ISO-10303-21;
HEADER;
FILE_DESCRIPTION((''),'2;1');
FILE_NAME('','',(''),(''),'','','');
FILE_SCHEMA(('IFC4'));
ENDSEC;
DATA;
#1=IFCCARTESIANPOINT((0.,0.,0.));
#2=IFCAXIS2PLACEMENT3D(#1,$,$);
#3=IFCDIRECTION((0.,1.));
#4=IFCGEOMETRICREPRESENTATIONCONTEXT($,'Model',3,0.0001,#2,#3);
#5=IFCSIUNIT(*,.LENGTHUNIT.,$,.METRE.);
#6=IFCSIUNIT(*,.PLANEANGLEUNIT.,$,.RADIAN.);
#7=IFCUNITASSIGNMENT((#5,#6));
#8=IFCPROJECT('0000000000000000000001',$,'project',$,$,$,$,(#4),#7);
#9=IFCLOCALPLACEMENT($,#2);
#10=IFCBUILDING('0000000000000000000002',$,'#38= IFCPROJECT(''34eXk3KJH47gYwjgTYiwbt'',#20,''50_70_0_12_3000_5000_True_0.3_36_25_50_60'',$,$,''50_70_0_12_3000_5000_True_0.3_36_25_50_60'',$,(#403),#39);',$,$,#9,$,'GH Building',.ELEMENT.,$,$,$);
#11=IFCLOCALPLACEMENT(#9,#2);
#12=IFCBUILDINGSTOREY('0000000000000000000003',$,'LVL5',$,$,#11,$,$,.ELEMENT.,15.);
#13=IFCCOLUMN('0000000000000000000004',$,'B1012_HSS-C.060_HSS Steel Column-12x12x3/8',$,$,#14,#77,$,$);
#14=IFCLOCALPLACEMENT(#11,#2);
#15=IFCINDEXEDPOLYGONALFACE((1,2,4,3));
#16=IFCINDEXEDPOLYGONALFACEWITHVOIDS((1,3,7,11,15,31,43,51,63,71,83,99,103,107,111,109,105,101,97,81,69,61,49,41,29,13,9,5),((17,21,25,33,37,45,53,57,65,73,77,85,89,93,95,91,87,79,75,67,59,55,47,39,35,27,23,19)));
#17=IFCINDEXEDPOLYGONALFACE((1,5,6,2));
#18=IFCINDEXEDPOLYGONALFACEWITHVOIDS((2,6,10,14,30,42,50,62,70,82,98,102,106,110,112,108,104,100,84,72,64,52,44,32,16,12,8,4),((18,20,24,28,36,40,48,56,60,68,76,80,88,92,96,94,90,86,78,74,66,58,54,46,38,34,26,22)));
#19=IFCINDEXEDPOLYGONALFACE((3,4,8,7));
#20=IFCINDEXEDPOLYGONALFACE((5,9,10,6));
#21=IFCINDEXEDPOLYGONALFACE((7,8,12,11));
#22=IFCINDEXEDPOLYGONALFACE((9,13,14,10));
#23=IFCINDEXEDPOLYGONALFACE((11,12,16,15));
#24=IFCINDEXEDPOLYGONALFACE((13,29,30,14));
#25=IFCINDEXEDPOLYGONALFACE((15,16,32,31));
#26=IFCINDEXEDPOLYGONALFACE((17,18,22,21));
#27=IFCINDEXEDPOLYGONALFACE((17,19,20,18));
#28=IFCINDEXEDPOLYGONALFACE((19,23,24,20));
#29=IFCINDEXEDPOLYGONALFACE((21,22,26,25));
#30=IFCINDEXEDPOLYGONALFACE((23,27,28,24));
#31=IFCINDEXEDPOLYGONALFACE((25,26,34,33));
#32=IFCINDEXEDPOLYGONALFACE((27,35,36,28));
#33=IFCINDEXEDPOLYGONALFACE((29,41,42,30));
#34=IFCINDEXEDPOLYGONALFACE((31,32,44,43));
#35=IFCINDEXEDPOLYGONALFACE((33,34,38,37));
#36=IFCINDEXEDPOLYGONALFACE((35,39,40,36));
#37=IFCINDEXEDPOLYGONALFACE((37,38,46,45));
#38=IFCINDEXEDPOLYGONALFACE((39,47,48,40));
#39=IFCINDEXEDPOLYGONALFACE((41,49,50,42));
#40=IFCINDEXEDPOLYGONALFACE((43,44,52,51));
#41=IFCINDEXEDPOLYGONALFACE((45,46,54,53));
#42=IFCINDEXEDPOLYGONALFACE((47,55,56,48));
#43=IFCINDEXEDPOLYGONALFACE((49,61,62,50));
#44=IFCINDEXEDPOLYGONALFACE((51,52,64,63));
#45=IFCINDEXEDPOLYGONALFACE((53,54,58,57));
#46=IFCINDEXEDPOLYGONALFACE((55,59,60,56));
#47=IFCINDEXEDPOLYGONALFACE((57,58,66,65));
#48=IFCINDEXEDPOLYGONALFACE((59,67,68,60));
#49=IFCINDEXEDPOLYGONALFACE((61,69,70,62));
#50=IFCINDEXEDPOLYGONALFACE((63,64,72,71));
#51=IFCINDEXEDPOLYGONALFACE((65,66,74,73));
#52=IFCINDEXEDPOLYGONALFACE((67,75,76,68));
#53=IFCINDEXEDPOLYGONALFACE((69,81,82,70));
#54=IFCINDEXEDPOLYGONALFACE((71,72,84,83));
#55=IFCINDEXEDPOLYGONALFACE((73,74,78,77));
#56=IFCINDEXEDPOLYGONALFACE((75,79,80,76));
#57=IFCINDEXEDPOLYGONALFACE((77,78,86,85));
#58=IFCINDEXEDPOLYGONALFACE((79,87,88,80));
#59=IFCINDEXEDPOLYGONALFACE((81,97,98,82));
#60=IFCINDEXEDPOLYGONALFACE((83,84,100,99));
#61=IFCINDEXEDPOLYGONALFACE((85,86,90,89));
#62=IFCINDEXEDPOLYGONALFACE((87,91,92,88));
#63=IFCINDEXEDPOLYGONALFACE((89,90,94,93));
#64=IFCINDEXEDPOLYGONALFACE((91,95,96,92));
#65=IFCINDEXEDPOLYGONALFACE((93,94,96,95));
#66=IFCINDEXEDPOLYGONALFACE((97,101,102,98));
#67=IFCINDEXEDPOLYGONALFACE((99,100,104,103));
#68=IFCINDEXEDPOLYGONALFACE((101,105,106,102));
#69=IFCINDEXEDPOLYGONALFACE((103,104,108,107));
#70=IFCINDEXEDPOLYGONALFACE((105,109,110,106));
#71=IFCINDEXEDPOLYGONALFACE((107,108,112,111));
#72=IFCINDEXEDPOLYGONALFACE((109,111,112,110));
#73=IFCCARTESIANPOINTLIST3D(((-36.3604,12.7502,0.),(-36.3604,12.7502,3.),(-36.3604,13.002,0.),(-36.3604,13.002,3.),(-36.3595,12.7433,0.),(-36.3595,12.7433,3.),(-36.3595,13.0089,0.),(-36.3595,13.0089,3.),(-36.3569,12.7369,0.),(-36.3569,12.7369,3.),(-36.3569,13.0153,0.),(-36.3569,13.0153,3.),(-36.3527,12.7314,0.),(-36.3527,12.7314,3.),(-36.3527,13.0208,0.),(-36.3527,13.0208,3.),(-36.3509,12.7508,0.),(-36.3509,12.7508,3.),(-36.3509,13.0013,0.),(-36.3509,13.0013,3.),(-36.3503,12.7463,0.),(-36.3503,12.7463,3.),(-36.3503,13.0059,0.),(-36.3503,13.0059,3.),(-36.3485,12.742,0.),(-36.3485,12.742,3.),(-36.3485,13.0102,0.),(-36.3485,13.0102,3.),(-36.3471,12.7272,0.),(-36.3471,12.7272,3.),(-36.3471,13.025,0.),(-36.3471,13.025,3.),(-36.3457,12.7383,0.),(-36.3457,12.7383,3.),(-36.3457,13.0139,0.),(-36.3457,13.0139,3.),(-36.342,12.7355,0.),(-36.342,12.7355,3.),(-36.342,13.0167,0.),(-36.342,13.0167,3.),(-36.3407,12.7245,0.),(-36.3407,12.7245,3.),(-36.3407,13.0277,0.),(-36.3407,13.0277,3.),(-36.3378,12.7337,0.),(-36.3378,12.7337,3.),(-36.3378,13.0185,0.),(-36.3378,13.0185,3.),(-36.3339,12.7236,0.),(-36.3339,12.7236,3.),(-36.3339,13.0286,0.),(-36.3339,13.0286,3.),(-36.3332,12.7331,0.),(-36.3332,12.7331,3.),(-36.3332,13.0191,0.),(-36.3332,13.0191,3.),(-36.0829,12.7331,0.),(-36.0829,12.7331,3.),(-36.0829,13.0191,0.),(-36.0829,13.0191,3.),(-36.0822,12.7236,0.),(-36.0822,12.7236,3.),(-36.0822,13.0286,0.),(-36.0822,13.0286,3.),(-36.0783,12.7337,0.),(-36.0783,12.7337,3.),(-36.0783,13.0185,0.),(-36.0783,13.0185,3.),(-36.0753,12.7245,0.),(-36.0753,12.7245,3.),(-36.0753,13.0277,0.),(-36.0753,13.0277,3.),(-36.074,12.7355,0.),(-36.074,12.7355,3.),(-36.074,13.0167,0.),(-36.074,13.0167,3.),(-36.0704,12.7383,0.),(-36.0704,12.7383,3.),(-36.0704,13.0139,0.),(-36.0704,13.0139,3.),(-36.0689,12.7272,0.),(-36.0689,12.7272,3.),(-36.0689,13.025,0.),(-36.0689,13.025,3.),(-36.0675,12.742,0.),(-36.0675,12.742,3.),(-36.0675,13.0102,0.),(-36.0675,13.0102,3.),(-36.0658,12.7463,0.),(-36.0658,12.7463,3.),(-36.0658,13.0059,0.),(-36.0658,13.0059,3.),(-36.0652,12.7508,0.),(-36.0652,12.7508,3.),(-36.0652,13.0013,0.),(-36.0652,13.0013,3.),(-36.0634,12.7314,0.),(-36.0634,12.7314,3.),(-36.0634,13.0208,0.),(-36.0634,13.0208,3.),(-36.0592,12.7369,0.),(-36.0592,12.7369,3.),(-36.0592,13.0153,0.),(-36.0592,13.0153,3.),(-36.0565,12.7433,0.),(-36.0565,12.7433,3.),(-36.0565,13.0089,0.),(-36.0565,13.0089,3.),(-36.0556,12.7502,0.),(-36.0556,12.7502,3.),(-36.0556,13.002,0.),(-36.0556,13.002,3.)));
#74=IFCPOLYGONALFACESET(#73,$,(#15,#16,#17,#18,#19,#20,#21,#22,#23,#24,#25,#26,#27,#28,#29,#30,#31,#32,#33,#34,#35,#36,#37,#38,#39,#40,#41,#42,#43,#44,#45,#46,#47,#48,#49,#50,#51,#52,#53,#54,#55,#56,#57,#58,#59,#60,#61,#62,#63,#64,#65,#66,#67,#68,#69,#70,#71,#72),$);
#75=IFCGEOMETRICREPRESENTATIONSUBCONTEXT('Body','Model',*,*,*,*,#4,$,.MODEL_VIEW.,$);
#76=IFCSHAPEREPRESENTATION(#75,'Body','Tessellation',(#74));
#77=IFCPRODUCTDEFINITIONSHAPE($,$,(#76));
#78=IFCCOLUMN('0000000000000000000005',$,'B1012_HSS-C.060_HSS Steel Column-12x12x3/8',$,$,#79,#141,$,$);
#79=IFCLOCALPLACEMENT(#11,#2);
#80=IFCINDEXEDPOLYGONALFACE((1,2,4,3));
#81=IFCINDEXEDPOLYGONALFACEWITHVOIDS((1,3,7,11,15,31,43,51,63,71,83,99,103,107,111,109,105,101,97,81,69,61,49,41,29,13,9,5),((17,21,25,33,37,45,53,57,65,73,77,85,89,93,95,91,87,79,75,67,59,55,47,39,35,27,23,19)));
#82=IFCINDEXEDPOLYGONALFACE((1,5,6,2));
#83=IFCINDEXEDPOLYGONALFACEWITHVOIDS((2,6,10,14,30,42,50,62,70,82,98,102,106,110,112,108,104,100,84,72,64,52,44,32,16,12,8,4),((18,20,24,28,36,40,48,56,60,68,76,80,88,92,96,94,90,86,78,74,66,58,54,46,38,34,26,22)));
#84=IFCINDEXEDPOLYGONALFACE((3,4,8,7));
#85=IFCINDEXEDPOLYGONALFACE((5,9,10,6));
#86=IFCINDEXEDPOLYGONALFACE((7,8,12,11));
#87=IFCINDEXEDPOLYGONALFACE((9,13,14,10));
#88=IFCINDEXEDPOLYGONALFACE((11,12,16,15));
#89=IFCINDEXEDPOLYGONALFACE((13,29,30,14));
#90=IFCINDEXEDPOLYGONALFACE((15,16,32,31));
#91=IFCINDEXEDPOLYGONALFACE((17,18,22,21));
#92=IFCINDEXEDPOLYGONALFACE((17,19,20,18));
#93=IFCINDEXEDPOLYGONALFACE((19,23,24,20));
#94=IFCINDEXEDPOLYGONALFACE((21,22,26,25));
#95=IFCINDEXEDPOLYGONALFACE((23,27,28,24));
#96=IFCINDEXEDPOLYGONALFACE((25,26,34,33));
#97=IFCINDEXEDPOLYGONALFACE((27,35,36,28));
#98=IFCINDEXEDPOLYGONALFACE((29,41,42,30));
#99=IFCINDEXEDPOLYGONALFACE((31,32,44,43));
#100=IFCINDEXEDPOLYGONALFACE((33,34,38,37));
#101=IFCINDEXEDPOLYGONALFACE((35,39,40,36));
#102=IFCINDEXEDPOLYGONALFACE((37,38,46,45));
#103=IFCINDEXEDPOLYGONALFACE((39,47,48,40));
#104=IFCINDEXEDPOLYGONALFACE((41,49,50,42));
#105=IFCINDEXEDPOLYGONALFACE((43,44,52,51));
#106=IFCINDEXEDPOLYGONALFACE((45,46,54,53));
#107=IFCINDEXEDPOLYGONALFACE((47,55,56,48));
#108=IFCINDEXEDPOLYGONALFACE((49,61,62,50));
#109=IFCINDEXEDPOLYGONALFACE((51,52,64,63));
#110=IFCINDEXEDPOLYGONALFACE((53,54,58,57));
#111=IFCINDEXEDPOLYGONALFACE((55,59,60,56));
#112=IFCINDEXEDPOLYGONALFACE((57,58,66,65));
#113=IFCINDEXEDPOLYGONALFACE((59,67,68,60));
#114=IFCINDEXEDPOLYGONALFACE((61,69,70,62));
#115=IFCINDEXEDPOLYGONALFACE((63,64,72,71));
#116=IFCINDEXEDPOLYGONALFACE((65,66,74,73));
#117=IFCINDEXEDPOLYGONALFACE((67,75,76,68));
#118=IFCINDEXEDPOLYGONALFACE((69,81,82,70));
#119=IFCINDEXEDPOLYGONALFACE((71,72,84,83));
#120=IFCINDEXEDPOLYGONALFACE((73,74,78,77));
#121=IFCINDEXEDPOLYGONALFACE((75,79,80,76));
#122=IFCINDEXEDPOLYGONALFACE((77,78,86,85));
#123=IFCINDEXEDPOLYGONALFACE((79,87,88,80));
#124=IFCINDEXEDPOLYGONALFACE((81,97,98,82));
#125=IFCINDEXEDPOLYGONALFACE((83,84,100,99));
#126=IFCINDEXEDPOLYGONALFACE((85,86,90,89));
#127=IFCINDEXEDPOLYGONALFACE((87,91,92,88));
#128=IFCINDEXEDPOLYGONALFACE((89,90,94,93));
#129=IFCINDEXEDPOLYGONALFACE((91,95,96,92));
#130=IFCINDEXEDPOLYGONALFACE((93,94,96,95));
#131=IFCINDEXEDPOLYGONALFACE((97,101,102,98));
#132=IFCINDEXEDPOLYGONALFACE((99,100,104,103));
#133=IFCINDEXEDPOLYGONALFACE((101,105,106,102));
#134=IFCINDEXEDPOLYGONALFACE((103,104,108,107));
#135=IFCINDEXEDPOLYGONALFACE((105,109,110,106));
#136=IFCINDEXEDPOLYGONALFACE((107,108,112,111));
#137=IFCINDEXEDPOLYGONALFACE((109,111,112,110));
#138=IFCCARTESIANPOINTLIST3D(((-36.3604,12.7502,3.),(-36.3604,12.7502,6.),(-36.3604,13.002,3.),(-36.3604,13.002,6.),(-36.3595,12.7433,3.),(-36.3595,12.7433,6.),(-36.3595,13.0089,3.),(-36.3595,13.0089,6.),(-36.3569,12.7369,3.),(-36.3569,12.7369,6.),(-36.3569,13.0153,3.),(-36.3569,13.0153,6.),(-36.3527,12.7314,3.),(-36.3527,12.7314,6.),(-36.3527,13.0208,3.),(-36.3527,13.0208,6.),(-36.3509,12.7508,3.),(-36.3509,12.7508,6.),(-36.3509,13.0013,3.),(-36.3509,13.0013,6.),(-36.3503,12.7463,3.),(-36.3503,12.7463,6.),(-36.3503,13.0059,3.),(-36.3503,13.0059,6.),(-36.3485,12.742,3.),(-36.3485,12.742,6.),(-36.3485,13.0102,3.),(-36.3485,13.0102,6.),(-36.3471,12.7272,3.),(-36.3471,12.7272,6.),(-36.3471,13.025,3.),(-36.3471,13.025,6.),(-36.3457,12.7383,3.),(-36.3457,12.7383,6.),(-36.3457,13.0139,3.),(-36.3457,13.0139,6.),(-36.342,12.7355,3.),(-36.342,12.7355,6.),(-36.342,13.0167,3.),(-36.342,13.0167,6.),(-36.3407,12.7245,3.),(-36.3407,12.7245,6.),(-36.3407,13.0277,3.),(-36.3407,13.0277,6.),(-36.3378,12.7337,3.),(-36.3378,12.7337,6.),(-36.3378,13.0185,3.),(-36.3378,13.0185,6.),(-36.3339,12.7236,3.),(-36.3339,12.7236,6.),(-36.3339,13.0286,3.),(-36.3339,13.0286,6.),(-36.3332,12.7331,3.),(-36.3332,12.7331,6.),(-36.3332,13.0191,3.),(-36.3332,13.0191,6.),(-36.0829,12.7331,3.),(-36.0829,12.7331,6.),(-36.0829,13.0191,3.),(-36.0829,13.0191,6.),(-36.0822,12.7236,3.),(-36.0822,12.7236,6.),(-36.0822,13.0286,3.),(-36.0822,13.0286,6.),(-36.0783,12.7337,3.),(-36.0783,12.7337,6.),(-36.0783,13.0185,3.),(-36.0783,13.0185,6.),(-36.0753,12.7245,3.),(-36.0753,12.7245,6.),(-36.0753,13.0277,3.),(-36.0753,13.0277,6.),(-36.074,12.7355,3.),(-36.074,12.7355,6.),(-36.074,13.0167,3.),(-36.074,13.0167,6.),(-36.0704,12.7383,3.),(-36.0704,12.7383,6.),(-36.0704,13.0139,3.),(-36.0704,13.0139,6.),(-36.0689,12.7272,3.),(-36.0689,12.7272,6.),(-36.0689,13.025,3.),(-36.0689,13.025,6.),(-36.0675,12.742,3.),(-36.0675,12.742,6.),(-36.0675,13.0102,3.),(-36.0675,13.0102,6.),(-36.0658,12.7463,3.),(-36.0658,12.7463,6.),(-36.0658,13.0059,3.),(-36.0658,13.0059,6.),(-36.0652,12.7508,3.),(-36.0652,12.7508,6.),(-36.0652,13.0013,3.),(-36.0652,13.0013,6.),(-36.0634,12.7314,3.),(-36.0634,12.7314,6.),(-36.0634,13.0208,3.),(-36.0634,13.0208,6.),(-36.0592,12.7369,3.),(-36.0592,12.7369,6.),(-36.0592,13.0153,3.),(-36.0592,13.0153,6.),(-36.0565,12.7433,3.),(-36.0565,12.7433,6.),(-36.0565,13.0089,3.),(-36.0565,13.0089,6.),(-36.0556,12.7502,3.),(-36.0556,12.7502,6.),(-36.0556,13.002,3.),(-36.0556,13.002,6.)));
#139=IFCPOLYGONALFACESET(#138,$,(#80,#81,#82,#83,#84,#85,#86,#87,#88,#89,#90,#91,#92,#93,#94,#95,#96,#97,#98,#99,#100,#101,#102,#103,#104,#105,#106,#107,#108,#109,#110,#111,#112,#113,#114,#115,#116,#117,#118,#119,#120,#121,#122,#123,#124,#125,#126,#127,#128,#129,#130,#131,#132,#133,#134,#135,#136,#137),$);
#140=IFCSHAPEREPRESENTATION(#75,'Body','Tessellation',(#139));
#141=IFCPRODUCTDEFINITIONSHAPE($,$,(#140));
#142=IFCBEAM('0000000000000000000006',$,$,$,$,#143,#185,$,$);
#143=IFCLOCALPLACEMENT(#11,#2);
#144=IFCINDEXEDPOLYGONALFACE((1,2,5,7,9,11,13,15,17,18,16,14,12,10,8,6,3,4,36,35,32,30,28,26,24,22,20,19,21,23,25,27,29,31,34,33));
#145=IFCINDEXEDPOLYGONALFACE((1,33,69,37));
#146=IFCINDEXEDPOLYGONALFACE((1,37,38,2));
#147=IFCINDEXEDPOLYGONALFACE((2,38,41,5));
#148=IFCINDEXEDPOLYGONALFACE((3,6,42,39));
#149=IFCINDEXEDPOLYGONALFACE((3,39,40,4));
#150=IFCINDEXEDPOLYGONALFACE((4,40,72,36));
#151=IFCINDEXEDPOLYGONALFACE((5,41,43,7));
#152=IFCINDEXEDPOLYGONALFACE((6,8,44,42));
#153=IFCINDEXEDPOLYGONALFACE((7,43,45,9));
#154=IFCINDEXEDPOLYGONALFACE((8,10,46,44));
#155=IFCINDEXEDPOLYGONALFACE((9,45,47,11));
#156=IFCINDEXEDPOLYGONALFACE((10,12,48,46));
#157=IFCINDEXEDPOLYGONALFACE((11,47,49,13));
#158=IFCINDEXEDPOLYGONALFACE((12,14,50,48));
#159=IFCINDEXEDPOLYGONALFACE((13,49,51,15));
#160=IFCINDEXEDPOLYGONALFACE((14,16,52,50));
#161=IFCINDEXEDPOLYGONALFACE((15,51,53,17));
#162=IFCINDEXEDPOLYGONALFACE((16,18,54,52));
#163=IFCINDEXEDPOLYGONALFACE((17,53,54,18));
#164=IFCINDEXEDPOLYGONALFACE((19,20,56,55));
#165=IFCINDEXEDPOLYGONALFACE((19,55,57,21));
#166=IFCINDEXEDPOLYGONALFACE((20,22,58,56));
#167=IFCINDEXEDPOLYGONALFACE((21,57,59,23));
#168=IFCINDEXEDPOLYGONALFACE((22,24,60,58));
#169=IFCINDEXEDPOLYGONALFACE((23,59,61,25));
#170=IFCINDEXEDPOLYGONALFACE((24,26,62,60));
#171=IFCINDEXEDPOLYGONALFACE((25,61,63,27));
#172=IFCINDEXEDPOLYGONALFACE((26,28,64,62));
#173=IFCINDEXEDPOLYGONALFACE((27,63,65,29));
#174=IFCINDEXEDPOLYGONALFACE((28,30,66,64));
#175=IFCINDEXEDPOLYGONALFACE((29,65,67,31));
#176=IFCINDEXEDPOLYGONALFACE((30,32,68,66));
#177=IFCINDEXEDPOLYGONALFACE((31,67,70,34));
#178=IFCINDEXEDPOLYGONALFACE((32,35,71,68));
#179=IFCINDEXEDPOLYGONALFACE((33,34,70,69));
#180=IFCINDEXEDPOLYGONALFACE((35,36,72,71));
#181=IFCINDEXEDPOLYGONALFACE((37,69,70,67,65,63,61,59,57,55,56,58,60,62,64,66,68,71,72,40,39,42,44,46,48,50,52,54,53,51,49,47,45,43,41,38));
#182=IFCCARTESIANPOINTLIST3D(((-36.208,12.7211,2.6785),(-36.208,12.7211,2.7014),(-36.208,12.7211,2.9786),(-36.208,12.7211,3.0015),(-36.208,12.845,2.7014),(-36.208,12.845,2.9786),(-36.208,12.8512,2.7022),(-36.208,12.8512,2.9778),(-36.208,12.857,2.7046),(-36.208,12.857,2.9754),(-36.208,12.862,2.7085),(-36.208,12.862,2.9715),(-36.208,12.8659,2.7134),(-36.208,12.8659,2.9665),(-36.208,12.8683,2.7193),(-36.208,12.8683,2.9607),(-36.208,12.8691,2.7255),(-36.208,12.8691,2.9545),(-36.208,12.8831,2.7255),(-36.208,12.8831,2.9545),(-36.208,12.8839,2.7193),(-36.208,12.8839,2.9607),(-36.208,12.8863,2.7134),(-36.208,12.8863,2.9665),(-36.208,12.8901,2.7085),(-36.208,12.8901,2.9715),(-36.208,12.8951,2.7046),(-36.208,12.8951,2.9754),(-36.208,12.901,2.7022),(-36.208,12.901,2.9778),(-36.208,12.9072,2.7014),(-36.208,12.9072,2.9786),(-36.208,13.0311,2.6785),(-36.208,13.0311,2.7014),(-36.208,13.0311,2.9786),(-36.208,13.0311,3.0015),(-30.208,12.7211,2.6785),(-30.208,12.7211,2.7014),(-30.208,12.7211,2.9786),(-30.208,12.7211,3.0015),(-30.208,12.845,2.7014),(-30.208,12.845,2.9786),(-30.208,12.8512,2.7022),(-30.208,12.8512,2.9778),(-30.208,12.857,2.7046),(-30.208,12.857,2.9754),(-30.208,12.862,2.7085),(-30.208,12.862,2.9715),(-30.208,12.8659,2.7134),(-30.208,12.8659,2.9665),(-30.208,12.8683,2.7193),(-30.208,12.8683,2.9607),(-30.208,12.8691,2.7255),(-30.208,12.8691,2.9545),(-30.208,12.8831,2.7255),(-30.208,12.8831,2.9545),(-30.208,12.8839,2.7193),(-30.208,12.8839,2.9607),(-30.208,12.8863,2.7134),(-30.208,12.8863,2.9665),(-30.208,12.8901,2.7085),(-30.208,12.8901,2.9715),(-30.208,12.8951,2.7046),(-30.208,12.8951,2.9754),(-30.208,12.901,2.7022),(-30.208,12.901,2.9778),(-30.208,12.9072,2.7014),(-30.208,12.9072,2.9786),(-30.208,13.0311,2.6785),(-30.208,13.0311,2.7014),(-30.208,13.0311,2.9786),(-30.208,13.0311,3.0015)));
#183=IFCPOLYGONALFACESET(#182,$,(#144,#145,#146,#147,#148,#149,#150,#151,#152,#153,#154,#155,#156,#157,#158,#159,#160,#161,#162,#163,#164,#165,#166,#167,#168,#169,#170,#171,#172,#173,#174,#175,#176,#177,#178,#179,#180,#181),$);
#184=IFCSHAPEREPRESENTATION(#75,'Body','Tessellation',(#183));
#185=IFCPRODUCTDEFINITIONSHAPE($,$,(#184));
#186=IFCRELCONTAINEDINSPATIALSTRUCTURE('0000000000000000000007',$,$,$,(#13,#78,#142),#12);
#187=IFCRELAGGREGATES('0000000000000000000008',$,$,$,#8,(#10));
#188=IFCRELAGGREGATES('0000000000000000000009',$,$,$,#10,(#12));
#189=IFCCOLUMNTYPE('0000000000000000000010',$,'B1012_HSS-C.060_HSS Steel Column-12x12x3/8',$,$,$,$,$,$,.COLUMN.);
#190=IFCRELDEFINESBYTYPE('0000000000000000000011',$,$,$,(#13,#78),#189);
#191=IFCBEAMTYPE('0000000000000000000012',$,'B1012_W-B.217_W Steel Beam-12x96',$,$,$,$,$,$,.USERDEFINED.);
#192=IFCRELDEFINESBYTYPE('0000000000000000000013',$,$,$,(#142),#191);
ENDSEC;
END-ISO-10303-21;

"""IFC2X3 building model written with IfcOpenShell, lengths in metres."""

from ifc_helpers import new_model, si_unit, direction, frame, origin, origin_2d, place, context, subcontext, project, spatial, hollow_rectangle, i_section, extrude, type_object, element, save


model = new_model("IFC2X3")

# Units and contexts
model_context = context("Model", 3, precision=0.0001, world=origin(), true_north=direction((0.0, 1.0)))
body_context = subcontext(model_context, "Body", "Model", "MODEL_VIEW")
ifc_project = project(units=[si_unit("LENGTHUNIT", "METRE"), si_unit("PLANEANGLEUNIT", "RADIAN")], contexts=[model_context])

# Building, storey
building_placement = place(None, origin())
building = spatial("IfcBuilding", under=ifc_project, at=building_placement, Name="#38= IFCPROJECT('34eXk3KJH47gYwjgTYiwbt',#20,'50_70_0_12_3000_5000_True_0.3_36_25_50_60',$,$,'50_70_0_12_3000_5000_True_0.3_36_25_50_60',$,(#403),#39);", LongName="GH Building", CompositionType="ELEMENT")
storey_placement = place(building_placement, origin())
storey = spatial("IfcBuildingStorey", under=building, at=storey_placement, Name="LVL5", CompositionType="ELEMENT", Elevation=15.0)

# Columns
column_type = type_object("IfcColumnType", Name="B1012_HSS-C.060_HSS Steel Column-12x12x3/8", PredefinedType="COLUMN")
for number, where, z_axis, x_axis, name in (
    (1, (-36.208, 12.8761, 3.0), (0.0, 0.0, -1.0), (-1.0, 0.0, 0.0), "B1012_HSS-C.060_HSS Steel Column-12x12x3/8"),
    (2, (-36.208, 12.8761, 6.0), (0.0, 0.0, -1.0), (-1.0, 0.0, 0.0), "B1012_HSS-C.060_HSS Steel Column-12x12x3/8"),
):
    element("IfcColumn", number, at=place(storey_placement, frame(where, z_axis=z_axis, x_axis=x_axis)), inside=storey, type_object=column_type, Name=name, context=body_context, shape_type="SweptSolid", body=[
        extrude(hollow_rectangle(XDim=0.3048, YDim=0.305, WallThickness=0.0095, InnerFilletRadius=0.0177, OuterFilletRadius=0.0266, at=origin_2d()), origin(), (0.0, 0.0, 1.0), 3.0),
    ])

# Beam
beam_type = type_object("IfcBeamType", Name="B1012_W-B.217_W Steel Beam-12x96", PredefinedType="USERDEFINED")
for number, where, z_axis, x_axis in (
    (3, (-36.208, 12.8761, 2.84), (1.0, 0.0, 0.0), (0.0, 1.0, 0.0)),
):
    element("IfcBeam", number, at=place(storey_placement, frame(where, z_axis=z_axis, x_axis=x_axis)), inside=storey, type_object=beam_type, context=body_context, shape_type="SweptSolid", body=[
        extrude(i_section(OverallWidth=0.31, OverallDepth=0.323, WebThickness=0.014, FlangeThickness=0.0229, FilletRadius=0.0241, at=origin_2d()), origin(), (0.0, 0.0, 1.0), 6.0),
    ])

save(model, "model.ifc")
